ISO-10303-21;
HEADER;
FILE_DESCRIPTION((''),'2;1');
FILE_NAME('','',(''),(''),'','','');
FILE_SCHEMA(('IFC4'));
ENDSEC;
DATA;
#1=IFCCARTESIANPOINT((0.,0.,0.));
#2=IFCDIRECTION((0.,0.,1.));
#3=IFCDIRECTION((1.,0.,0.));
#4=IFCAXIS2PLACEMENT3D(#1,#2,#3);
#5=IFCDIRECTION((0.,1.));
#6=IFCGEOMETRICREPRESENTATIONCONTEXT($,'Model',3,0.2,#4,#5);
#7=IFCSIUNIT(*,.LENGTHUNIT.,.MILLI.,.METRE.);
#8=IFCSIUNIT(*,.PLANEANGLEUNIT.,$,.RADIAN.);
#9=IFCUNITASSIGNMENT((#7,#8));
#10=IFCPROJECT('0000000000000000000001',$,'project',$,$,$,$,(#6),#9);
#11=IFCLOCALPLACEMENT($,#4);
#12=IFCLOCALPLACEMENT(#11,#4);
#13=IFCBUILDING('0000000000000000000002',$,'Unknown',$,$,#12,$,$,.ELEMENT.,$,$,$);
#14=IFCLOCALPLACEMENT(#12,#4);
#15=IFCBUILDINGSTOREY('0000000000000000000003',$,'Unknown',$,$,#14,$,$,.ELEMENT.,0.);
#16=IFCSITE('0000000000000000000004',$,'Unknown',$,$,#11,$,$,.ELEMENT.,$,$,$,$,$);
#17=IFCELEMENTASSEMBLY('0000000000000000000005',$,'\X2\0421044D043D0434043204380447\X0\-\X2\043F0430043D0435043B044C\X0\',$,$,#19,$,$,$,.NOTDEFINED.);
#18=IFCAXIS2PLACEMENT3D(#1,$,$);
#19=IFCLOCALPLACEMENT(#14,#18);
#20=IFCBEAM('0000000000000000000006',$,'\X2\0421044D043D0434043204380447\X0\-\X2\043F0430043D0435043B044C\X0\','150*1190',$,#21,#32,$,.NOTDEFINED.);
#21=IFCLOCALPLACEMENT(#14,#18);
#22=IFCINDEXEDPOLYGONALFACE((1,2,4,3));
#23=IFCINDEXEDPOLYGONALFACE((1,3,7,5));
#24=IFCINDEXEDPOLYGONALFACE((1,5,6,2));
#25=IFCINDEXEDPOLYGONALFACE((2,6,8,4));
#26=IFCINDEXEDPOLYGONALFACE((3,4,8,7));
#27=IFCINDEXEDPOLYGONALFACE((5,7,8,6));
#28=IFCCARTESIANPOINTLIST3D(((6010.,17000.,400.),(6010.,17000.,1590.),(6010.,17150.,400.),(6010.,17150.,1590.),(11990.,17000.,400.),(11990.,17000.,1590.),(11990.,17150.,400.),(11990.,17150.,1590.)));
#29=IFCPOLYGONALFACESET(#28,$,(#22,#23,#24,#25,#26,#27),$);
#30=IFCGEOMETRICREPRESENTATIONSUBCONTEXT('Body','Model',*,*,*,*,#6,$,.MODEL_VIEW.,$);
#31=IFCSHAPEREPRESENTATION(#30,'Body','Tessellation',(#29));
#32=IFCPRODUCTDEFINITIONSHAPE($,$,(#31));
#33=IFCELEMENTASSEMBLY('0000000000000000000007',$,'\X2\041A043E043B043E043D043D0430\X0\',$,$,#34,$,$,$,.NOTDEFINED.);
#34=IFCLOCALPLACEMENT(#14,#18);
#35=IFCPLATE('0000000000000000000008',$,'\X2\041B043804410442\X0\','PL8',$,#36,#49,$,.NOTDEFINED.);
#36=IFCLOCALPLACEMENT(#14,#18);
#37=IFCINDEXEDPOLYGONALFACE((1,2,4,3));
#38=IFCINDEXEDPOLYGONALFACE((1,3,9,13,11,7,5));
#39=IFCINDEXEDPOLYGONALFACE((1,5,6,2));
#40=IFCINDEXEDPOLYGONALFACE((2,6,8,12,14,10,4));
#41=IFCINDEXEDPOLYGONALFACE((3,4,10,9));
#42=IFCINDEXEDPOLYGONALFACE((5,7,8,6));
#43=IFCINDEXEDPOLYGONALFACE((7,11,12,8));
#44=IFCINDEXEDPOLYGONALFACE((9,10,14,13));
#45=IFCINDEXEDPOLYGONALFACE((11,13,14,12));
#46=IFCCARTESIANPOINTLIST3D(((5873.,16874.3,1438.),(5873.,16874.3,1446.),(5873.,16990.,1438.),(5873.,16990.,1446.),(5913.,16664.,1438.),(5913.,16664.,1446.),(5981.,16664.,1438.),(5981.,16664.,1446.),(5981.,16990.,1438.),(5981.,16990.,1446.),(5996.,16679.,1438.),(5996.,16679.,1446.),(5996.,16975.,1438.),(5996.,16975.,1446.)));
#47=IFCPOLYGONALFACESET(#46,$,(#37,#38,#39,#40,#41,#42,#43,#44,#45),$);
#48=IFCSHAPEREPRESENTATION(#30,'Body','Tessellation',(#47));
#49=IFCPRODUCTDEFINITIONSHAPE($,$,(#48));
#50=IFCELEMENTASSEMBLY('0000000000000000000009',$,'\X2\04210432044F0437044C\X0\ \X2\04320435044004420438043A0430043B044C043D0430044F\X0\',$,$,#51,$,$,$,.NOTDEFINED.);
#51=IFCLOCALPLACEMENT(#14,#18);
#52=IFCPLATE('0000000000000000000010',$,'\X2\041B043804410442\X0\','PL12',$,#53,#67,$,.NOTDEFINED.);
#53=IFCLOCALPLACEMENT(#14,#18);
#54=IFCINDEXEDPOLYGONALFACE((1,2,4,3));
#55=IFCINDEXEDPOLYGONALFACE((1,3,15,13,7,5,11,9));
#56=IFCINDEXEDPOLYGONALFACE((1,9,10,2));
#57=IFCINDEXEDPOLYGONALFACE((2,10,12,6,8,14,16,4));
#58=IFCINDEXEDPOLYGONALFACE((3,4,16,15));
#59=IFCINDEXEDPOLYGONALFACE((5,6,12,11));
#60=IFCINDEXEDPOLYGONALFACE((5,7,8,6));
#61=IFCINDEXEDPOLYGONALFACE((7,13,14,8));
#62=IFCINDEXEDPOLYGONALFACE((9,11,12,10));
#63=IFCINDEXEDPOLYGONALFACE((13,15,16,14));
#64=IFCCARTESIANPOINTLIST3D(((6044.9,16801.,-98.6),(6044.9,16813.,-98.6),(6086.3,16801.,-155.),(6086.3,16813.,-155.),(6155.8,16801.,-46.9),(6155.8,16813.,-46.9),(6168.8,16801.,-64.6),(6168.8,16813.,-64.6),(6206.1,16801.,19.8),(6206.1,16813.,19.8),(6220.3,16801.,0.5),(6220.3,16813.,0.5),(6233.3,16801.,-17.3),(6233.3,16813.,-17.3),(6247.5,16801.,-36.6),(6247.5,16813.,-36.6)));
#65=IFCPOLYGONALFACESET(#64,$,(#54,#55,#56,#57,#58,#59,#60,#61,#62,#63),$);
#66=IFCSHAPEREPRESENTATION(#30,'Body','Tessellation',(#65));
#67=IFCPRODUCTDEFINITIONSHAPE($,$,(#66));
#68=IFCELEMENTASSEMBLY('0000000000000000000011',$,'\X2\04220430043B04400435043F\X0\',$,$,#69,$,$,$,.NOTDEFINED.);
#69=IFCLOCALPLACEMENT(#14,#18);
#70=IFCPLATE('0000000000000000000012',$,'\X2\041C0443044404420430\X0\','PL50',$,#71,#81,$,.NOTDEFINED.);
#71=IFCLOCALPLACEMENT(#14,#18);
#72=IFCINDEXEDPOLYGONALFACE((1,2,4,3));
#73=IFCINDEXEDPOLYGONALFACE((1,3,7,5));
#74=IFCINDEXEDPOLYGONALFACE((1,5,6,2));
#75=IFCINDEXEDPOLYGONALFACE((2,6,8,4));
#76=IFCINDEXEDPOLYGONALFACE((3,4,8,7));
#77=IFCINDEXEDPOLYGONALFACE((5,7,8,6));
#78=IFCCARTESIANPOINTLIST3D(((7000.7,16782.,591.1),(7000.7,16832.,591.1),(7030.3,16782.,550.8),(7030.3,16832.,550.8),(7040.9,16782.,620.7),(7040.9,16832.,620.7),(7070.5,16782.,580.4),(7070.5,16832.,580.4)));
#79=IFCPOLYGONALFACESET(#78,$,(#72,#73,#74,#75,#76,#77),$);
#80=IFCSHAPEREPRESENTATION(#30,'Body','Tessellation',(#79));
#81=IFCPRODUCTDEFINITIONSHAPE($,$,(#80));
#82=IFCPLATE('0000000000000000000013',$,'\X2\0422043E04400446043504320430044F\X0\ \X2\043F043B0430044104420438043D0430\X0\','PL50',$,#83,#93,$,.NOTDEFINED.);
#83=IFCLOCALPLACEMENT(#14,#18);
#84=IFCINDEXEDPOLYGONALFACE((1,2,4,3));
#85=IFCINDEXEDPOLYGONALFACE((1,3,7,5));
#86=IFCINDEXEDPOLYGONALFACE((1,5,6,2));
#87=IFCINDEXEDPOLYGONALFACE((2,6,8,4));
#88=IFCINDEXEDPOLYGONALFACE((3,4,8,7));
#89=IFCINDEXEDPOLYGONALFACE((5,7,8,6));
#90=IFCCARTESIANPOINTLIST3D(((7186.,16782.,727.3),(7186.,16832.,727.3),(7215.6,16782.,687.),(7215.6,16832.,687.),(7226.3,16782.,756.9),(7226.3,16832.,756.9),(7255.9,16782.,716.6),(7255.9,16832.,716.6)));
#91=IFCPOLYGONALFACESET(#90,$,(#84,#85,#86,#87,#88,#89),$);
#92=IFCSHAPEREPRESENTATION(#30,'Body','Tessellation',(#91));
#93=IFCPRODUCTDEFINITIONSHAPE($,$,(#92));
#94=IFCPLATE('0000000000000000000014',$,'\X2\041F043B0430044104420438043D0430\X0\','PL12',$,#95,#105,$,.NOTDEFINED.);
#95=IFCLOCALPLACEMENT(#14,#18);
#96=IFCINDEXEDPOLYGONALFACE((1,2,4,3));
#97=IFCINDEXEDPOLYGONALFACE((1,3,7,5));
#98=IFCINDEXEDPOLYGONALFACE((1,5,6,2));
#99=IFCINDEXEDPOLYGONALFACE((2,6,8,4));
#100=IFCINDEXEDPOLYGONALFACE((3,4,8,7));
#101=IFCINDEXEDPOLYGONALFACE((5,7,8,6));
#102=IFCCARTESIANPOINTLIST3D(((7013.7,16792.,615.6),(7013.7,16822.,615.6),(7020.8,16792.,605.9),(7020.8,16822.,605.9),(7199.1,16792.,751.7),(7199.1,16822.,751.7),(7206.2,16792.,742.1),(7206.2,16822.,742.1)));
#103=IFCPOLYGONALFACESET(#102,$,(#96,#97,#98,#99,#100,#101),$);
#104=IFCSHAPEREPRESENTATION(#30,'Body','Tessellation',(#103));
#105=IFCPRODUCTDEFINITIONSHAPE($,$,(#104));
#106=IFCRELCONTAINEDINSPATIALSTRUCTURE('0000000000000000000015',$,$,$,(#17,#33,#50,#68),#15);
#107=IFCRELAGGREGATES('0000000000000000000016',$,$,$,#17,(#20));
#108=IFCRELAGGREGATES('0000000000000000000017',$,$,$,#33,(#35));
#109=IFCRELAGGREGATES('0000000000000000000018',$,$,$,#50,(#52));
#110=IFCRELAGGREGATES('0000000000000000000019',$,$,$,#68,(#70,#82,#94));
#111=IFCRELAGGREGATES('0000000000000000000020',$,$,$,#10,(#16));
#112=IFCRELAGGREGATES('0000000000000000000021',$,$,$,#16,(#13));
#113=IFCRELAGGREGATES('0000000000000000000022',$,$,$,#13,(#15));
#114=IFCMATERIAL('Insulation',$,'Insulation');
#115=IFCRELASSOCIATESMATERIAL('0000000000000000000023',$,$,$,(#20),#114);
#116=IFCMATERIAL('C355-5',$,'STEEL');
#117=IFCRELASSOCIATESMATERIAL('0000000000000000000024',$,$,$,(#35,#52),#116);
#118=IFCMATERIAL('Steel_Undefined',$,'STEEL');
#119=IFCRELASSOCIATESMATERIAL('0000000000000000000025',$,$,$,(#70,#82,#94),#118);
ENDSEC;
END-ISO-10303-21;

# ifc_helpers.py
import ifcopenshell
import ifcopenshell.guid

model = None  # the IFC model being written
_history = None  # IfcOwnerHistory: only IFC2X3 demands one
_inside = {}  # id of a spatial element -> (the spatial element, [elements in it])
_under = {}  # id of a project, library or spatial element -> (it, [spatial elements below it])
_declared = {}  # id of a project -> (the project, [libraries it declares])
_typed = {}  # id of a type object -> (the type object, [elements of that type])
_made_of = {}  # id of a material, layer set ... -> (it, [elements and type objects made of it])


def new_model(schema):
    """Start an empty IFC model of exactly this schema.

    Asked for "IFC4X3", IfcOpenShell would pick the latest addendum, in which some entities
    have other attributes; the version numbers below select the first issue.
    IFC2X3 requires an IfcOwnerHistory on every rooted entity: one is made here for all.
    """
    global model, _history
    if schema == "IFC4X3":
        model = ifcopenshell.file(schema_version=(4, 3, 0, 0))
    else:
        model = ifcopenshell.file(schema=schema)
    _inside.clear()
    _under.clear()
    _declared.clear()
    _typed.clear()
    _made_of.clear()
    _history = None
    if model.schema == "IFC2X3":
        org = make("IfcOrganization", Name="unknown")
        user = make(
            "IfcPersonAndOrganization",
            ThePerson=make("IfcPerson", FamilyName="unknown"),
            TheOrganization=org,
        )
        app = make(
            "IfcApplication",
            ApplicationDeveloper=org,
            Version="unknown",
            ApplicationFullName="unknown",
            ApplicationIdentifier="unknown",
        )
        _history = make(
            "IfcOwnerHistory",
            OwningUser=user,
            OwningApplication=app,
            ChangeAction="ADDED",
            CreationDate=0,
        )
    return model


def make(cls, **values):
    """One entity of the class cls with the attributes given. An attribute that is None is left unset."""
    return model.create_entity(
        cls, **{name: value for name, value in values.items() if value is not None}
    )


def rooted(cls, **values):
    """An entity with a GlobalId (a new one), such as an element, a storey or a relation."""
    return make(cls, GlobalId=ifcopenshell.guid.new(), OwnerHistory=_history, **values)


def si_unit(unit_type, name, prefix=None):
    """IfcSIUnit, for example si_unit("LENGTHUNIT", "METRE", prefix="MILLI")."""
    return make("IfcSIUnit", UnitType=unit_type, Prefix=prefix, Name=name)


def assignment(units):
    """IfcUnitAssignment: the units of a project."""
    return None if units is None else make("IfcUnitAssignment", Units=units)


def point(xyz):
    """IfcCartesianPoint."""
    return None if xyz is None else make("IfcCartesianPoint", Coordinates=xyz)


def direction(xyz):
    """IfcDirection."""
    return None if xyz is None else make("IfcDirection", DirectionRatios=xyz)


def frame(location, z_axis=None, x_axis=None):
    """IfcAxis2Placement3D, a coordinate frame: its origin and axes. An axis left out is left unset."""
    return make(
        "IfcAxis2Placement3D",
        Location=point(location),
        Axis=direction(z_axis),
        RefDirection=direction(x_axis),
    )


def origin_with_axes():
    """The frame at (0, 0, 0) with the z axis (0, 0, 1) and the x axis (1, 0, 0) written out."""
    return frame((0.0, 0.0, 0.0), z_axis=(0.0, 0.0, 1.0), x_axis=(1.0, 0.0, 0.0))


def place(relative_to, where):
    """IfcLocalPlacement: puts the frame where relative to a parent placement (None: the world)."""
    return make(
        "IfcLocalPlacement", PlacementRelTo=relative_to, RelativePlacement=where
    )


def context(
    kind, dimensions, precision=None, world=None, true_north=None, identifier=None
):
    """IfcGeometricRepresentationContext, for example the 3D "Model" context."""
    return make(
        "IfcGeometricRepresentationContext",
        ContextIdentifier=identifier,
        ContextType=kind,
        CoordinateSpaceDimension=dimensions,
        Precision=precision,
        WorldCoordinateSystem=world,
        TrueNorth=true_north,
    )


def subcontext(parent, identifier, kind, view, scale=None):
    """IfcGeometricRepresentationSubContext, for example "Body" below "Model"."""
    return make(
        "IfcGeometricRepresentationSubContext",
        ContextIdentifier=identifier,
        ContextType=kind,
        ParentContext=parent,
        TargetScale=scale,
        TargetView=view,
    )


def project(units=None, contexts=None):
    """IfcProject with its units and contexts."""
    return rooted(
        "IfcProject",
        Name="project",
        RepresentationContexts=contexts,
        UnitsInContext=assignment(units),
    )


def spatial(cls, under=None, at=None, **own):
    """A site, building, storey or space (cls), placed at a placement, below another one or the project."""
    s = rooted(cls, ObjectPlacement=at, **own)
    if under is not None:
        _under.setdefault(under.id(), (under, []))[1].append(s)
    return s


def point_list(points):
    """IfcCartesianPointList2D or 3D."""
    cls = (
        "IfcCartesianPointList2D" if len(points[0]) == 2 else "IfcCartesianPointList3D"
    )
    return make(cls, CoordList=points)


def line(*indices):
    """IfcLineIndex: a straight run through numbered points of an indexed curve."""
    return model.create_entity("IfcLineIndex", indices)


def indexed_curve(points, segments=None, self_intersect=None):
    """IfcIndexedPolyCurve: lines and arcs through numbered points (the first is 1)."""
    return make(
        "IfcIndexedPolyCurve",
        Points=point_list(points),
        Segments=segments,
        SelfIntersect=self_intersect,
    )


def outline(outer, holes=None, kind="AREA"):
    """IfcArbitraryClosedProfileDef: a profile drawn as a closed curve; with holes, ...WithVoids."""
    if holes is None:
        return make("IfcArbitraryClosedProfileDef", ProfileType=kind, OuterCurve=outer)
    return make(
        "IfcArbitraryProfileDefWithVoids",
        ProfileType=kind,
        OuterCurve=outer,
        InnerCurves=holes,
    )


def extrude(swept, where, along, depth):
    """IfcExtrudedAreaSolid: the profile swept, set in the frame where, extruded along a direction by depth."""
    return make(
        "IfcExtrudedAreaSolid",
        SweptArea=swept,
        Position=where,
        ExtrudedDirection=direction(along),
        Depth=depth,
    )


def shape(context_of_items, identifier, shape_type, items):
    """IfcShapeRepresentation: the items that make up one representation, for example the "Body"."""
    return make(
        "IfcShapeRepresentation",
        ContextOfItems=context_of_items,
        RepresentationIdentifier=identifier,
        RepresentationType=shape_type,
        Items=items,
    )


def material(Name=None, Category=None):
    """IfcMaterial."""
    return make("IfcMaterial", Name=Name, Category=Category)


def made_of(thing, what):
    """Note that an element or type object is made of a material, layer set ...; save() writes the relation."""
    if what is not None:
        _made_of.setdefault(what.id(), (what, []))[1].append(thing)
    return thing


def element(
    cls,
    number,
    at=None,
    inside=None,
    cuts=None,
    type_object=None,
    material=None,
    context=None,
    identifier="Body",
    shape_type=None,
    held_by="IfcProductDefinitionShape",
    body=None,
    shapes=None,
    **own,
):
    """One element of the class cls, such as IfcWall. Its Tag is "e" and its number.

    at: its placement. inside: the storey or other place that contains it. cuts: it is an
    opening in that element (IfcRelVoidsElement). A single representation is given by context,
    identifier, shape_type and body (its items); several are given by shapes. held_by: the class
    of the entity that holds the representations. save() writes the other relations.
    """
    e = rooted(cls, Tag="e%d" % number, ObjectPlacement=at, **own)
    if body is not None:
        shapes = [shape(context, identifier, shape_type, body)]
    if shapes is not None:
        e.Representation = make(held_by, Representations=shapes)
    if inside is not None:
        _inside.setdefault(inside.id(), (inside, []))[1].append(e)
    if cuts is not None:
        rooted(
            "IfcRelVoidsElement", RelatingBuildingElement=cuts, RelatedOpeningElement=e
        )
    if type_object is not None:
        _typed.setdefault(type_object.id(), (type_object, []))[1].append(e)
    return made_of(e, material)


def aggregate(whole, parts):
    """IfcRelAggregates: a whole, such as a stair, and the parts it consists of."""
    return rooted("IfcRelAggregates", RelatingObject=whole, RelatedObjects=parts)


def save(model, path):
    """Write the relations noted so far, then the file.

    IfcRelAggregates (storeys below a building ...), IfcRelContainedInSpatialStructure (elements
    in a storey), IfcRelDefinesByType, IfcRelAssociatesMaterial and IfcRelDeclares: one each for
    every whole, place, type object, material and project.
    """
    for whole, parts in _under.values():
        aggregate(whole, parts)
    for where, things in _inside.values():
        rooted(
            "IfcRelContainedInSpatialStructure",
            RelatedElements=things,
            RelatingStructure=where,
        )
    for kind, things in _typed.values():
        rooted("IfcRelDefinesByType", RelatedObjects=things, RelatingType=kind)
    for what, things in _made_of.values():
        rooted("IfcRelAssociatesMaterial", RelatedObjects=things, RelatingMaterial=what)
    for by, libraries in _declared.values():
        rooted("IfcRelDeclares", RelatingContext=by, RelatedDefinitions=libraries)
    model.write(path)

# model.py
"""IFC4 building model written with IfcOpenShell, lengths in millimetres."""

from ifc_helpers import new_model, si_unit, direction, frame, origin_with_axes, place, context, subcontext, project, spatial, line, indexed_curve, outline, extrude, material, element, aggregate, save


model = new_model("IFC4")

# Units and contexts
model_context = context("Model", 3, precision=0.2, world=origin_with_axes(), true_north=direction((0.0, 1.0)))
body_context = subcontext(model_context, "Body", "Model", "MODEL_VIEW")
ifc_project = project(units=[si_unit("LENGTHUNIT", "METRE", prefix="MILLI"), si_unit("PLANEANGLEUNIT", "RADIAN")], contexts=[model_context])

# Site, building, storey
site_placement = place(None, origin_with_axes())
site = spatial("IfcSite", under=ifc_project, at=site_placement, Name="Unknown", CompositionType="ELEMENT")
building_placement = place(site_placement, origin_with_axes())
building = spatial("IfcBuilding", under=site, at=building_placement, Name="Unknown", CompositionType="ELEMENT")
storey_placement = place(building_placement, origin_with_axes())
storey = spatial("IfcBuildingStorey", under=building, at=storey_placement, Name="Unknown", CompositionType="ELEMENT", Elevation=0.0)

# Shared definitions
ifc_material_1 = material(Name="Steel_Undefined", Category="STEEL")

# Shared definitions
ifc_material_2 = material(Name="C355-5", Category="STEEL")

# Element assembly, beam
assembly_1_placement = place(storey_placement, frame((6010.0, 17075.0, 995.0), z_axis=(0.0, 0.0, -1.0), x_axis=(1.0, 0.0, 0.0)))
assembly_1 = element("IfcElementAssembly", 1, at=assembly_1_placement, inside=storey, Name="Сэндвич-панель", PredefinedType="NOTDEFINED")
ifc_material_3 = material(Name="Insulation", Category="Insulation")
beam_1_placement = place(assembly_1_placement, origin_with_axes())
beam_1 = element("IfcBeam", 2, at=beam_1_placement, material=ifc_material_3, Name="Сэндвич-панель", Description="150*1190", PredefinedType="NOTDEFINED", context=body_context, shape_type="SolidModel", body=[
    extrude(outline(indexed_curve([(-595.0, -75.0), (595.0, -75.0), (595.0, 75.0), (-595.0, 75.0)], segments=[line(1, 2, 3, 4, 1)])), frame((0.0, 0.0, 0.0), z_axis=(-1.0, 0.0, 0.0), x_axis=(0.0, 0.0, 1.0)), (0.0, 0.0, -1.0), 5980.0),
])
aggregate(assembly_1, [beam_1])

# Element assembly, plate
assembly_2_placement = place(storey_placement, frame((6000.0, 16827.0, -200.0), z_axis=(-1.0, 0.0, 0.0), x_axis=(0.0, 0.0, 1.0)))
assembly_2 = element("IfcElementAssembly", 3, at=assembly_2_placement, inside=storey, Name="Колонна", PredefinedType="NOTDEFINED")
plate_1_placement = place(assembly_2_placement, frame((1642.0, 163.0, 4.0), z_axis=(1.0, 0.0, 0.0), x_axis=(0.0, 0.0, 1.0)))
plate_1 = element("IfcPlate", 4, at=plate_1_placement, material=ifc_material_2, Name="Лист", Description="PL8", PredefinedType="NOTDEFINED", context=body_context, shape_type="SolidModel", body=[
    extrude(outline(indexed_curve([(0.0, 15.0), (15.0, 0.0), (123.0, 0.0), (123.0, 115.8), (83.0, 326.0), (15.0, 326.0), (0.0, 311.0)], segments=[line(1, 2, 3, 4, 5, 6, 7, 1)])), frame((0.0, 0.0, 4.0), z_axis=(0.0, 0.0, 1.0), x_axis=(1.0, 0.0, 0.0)), (0.0, 0.0, -1.0), 8.0),
])
aggregate(assembly_2, [plate_1])

# Element assembly, plate
assembly_3_placement = place(storey_placement, frame((7128.3, 16807.0, 653.8), z_axis=(0.0, 1.0, 0.0), x_axis=(-0.805914, 0.0, -0.592033)))
assembly_3 = element("IfcElementAssembly", 5, at=assembly_3_placement, inside=storey, Name="Связь вертикальная", PredefinedType="NOTDEFINED")
plate_2_placement = place(assembly_3_placement, frame((1118.6, 35.0, 0.0), z_axis=(0.0, 0.0, -1.0), x_axis=(1.0, 0.0, 0.0)))
plate_2 = element("IfcPlate", 6, at=plate_2_placement, material=ifc_material_2, Name="Лист", Description="PL12", PredefinedType="NOTDEFINED", context=body_context, shape_type="SolidModel", body=[
    extrude(outline(indexed_curve([(0.0, 0.0), (200.0, 0.0), (200.0, 70.0), (0.0, 70.0), (0.0, 46.0), (80.0, 46.0), (80.0, 24.0), (0.0, 24.0)], segments=[line(1, 2, 3, 4, 5, 6, 7, 8, 1)])), frame((0.0, 0.0, 6.0), z_axis=(0.0, 0.0, 1.0), x_axis=(1.0, 0.0, 0.0)), (0.0, 0.0, -1.0), 12.0),
])
aggregate(assembly_3, [plate_2])

# Element assembly, plates
assembly_4_placement = place(storey_placement, frame((7020.8, 16832.0, 605.9), z_axis=(0.805914, 0.0, 0.592033), x_axis=(0.0, -1.0, 0.0)))
assembly_4 = element("IfcElementAssembly", 7, at=assembly_4_placement, inside=storey, Name="Талреп", PredefinedType="NOTDEFINED")
plate_3_placement = place(assembly_4_placement, origin_with_axes())
plate_3 = element("IfcPlate", 8, at=plate_3_placement, material=ifc_material_1, Name="Муфта", Description="PL50", PredefinedType="NOTDEFINED", context=body_context, shape_type="SolidModel", body=[
    extrude(outline(indexed_curve([(0.0, 0.0), (50.0, 0.0), (50.0, 50.0), (0.0, 50.0)], segments=[line(1, 2, 3, 4, 1)])), frame((0.0, 0.0, 25.0), z_axis=(0.0, 0.0, 1.0), x_axis=(1.0, 0.0, 0.0)), (0.0, 0.0, -1.0), 50.0),
])
plate_4_placement = place(assembly_4_placement, frame((0.0, 0.0, 230.0), z_axis=(0.0, 0.0, 1.0), x_axis=(1.0, 0.0, 0.0)))
plate_4 = element("IfcPlate", 9, at=plate_4_placement, material=ifc_material_1, Name="Торцевая пластина", Description="PL50", PredefinedType="NOTDEFINED", context=body_context, shape_type="SolidModel", body=[
    extrude(outline(indexed_curve([(0.0, 0.0), (50.0, 0.0), (50.0, 50.0), (0.0, 50.0)], segments=[line(1, 2, 3, 4, 1)])), frame((0.0, 0.0, 25.0), z_axis=(0.0, 0.0, 1.0), x_axis=(1.0, 0.0, 0.0)), (0.0, 0.0, -1.0), 50.0),
])
plate_5_placement = place(assembly_4_placement, frame((10.0, -6.0, 230.0), z_axis=(0.0, 1.0, 0.0), x_axis=(1.0, 0.0, 0.0)))
plate_5 = element("IfcPlate", 10, at=plate_5_placement, material=ifc_material_1, Name="Пластина", Description="PL12", PredefinedType="NOTDEFINED", context=body_context, shape_type="SolidModel", body=[
    extrude(outline(indexed_curve([(0.0, 0.0), (30.0, 0.0), (30.0, 230.0), (0.0, 230.0)], segments=[line(1, 2, 3, 4, 1)])), frame((0.0, 0.0, 6.0), z_axis=(0.0, 0.0, 1.0), x_axis=(1.0, 0.0, 0.0)), (0.0, 0.0, -1.0), 12.0),
])
aggregate(assembly_4, [plate_3, plate_4, plate_5])

save(model, "model.ifc")
